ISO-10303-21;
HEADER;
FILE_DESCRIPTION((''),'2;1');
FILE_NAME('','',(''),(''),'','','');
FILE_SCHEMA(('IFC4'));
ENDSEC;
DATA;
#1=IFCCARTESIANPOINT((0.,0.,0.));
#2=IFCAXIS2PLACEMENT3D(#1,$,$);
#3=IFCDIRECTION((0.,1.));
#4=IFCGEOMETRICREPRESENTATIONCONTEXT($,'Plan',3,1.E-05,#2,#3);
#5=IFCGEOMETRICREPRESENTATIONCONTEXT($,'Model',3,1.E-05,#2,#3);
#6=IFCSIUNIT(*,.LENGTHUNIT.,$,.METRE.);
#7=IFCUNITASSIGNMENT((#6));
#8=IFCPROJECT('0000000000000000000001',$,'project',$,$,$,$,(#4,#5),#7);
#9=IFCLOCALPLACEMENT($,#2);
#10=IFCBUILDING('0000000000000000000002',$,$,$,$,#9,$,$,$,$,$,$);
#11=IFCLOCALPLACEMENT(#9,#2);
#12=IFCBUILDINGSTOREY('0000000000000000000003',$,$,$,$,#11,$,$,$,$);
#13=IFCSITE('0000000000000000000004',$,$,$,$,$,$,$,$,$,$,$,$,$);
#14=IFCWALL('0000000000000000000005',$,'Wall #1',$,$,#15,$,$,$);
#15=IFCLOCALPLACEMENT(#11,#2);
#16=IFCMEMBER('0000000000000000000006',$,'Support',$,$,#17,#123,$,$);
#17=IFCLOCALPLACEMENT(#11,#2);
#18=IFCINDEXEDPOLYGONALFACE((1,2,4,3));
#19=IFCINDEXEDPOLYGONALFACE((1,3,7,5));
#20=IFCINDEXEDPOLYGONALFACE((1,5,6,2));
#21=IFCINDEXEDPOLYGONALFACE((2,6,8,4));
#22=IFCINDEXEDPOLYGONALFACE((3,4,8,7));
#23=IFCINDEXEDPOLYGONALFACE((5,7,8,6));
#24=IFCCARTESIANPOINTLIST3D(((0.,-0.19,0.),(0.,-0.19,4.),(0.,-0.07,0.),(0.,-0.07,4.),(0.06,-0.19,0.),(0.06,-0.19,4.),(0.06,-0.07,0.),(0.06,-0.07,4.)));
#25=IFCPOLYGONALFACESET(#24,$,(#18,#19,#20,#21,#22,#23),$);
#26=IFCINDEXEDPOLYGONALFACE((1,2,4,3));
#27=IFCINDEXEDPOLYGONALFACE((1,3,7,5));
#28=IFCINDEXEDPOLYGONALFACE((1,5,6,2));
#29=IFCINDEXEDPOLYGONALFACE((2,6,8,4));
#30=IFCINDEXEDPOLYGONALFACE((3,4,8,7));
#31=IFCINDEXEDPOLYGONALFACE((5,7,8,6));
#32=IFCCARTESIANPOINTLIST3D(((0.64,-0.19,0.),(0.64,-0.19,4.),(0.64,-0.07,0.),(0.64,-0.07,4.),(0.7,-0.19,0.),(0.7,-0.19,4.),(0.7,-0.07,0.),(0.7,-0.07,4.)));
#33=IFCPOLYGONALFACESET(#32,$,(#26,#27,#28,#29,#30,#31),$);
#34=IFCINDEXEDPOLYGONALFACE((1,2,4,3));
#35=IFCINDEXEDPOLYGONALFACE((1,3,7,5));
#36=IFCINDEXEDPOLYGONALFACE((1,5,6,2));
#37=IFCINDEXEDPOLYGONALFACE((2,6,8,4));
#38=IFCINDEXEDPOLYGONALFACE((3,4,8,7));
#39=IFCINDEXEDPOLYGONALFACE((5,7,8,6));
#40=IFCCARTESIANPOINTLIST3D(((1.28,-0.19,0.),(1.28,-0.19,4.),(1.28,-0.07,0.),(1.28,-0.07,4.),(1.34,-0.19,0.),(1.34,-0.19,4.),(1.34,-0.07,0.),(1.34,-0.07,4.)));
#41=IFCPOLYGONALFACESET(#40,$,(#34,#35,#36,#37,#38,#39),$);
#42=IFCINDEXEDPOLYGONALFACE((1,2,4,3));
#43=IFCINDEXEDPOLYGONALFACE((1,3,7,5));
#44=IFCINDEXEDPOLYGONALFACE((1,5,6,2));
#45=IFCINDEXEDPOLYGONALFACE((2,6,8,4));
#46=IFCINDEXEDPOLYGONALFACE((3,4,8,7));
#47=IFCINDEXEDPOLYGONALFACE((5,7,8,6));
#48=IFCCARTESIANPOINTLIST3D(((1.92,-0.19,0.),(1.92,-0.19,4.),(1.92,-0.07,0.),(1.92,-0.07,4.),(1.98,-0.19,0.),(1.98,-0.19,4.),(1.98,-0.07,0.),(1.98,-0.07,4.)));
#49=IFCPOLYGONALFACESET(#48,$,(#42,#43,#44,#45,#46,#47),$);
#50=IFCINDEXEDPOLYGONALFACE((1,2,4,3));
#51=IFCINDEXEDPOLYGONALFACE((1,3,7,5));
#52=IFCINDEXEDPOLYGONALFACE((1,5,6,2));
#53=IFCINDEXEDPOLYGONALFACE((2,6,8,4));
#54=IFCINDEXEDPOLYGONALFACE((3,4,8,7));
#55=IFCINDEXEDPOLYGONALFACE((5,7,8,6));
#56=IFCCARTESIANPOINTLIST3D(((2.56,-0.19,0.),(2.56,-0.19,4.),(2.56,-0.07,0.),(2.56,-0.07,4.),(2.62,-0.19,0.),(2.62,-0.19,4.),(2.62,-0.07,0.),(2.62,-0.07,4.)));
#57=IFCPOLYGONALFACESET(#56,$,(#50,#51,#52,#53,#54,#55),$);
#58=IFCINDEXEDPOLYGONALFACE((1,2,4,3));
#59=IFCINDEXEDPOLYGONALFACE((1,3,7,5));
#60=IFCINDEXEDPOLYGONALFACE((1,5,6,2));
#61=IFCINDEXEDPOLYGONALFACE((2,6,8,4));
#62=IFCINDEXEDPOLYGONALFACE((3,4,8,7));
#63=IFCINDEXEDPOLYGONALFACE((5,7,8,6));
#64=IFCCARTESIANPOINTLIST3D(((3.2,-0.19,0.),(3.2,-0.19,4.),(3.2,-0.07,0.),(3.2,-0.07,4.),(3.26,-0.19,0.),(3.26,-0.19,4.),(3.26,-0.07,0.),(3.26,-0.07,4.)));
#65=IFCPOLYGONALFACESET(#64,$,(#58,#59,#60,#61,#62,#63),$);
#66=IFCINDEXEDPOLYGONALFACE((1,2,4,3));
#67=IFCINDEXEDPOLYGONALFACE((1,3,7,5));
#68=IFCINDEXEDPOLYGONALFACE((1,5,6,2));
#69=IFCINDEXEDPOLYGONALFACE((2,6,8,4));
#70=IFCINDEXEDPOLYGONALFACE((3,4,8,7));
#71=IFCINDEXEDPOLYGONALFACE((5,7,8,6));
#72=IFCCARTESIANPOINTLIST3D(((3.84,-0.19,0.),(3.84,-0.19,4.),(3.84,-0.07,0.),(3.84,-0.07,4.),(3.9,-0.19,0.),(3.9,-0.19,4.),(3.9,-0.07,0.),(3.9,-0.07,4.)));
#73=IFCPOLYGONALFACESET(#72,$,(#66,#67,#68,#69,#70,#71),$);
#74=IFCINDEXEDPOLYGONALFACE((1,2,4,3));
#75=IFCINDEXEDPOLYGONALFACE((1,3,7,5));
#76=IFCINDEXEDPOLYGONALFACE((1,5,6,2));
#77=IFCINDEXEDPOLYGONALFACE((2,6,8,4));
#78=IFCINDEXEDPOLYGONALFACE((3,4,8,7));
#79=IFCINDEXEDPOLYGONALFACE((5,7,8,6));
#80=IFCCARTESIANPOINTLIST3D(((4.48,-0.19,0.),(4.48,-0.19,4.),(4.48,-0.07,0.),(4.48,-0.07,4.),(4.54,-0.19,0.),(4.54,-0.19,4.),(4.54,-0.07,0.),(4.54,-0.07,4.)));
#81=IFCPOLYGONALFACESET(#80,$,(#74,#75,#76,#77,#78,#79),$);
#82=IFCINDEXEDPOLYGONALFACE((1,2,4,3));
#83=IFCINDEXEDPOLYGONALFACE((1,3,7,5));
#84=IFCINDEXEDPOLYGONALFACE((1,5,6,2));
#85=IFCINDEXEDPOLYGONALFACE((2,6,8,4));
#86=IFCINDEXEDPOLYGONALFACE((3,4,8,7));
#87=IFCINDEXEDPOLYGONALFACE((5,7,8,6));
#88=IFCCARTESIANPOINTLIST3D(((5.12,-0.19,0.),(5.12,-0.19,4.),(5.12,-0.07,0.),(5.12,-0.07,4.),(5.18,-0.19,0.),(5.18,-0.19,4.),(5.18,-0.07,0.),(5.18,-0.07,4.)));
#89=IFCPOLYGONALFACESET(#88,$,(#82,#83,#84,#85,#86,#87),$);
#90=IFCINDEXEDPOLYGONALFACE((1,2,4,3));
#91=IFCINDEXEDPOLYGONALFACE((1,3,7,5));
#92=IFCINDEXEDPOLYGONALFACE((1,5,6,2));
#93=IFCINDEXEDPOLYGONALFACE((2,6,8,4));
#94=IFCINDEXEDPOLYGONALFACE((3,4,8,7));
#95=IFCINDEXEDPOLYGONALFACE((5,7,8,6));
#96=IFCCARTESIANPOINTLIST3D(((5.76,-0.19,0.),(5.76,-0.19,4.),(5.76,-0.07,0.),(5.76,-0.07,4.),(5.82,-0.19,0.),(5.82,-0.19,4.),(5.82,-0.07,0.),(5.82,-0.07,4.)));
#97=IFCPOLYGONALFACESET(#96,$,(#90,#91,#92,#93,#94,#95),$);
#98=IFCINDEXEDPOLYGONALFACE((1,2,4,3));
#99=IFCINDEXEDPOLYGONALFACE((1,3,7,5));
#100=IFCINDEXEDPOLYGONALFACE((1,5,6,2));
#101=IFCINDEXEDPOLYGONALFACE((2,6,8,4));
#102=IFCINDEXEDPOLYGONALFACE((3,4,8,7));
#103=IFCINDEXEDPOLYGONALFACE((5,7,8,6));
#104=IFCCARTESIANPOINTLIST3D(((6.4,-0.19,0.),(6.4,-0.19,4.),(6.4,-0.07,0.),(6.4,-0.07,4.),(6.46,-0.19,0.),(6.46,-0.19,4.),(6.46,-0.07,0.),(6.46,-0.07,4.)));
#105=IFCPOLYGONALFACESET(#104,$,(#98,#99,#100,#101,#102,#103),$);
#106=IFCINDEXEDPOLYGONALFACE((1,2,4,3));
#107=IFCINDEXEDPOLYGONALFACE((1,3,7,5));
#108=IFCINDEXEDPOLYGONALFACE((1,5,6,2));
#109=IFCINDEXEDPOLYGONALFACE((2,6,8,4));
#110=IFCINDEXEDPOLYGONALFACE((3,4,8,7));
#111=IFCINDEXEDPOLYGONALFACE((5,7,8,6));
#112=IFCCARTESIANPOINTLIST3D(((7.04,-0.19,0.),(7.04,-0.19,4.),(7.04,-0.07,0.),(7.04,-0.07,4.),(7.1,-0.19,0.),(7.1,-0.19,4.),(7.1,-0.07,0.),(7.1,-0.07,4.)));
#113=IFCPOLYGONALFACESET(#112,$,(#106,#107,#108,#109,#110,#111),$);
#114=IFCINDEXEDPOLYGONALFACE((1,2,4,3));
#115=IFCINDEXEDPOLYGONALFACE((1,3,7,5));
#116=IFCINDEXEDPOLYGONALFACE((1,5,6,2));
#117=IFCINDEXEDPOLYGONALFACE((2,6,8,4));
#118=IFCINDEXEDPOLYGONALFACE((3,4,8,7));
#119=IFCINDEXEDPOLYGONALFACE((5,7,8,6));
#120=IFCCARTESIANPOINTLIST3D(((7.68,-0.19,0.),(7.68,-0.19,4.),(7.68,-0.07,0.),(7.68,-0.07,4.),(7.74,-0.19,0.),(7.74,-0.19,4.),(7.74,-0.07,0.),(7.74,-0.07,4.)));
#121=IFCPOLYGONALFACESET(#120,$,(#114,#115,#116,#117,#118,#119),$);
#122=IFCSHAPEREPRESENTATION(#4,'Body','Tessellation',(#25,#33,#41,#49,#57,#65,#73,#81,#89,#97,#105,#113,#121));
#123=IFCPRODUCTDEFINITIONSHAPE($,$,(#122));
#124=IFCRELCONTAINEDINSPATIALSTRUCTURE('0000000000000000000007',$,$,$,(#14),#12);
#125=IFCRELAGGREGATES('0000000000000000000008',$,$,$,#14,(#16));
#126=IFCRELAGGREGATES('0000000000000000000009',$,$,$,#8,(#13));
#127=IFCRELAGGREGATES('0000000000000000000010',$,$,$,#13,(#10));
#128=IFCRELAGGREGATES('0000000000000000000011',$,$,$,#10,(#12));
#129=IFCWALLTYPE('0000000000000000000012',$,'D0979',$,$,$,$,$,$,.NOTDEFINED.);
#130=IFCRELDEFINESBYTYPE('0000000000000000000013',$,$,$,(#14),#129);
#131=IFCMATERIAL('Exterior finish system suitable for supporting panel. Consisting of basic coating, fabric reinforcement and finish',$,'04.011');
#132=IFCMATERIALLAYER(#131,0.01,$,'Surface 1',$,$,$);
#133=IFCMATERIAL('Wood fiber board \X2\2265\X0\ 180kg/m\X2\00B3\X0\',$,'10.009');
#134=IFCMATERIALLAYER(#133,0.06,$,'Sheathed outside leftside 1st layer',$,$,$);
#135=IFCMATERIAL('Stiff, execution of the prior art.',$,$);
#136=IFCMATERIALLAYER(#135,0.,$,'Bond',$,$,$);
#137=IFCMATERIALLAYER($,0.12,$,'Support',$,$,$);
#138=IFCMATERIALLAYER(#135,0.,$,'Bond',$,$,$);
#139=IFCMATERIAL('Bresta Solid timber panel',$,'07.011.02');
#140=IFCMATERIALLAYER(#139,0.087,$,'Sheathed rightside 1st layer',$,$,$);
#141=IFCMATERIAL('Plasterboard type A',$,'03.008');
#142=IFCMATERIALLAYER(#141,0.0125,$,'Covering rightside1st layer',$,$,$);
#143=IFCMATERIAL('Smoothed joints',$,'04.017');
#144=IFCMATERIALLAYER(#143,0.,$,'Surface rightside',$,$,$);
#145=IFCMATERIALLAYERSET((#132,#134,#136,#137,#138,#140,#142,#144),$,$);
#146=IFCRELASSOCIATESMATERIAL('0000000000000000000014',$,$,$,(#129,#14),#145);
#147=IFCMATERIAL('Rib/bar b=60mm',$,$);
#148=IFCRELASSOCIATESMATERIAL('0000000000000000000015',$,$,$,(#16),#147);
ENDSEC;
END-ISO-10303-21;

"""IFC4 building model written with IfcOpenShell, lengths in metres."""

from ifc_helpers import new_model, si_unit, direction, frame, frame_2d, origin, place, context, project, spatial, rectangle, extrude, material, layer, layer_set, type_object, element, aggregate, save


model = new_model("IFC4")

# Units and contexts
plan_context = context("Plan", 3, precision=1e-05, world=origin(), true_north=direction((0.0, 1.0)))
model_context = context("Model", 3, precision=1e-05, world=origin(), true_north=direction((0.0, 1.0)))
ifc_project = project(units=[si_unit("LENGTHUNIT", "METRE")], contexts=[plan_context, model_context])

# Site, building, storey
site = spatial("IfcSite", under=ifc_project)
building_placement = place(None, origin())
building = spatial("IfcBuilding", under=site, at=building_placement)
storey_placement = place(building_placement, origin())
storey = spatial("IfcBuildingStorey", under=building, at=storey_placement)

# Wall, member
ifc_material_1 = material(Name="Exterior finish system suitable for supporting panel. Consisting of basic coating, fabric reinforcement and finish", Category="04.011")
ifc_layer_1 = layer(ifc_material_1, 0.01, Name="Surface 1")
ifc_material_2 = material(Name="Wood fiber board ≥ 180kg/m³", Category="10.009")
ifc_layer_2 = layer(ifc_material_2, 0.06, Name="Sheathed outside leftside 1st layer")
ifc_material_3 = material(Name="Stiff, execution of the prior art.")
ifc_layer_3 = layer(ifc_material_3, 0.0, Name="Bond")
ifc_layer_4 = layer(None, 0.12, Name="Support")
ifc_layer_5 = layer(ifc_material_3, 0.0, Name="Bond")
ifc_material_4 = material(Name="Bresta Solid timber panel", Category="07.011.02")
ifc_layer_6 = layer(ifc_material_4, 0.087, Name="Sheathed rightside 1st layer")
ifc_material_5 = material(Name="Plasterboard type A", Category="03.008")
ifc_layer_7 = layer(ifc_material_5, 0.0125, Name="Covering rightside1st layer")
ifc_material_6 = material(Name="Smoothed joints", Category="04.017")
ifc_layer_8 = layer(ifc_material_6, 0.0, Name="Surface rightside")
ifc_layer_set = layer_set([ifc_layer_1, ifc_layer_2, ifc_layer_3, ifc_layer_4, ifc_layer_5, ifc_layer_6, ifc_layer_7, ifc_layer_8])
wall_type = type_object("IfcWallType", Name="D0979", PredefinedType="NOTDEFINED", material=ifc_layer_set)
wall_placement = place(None, frame((0.0, 0.0, 0.0), z_axis=(0.0, -1.0, 0.0), x_axis=(1.0, 0.0, 0.0)))
wall = element("IfcWall", 1, at=wall_placement, inside=storey, type_object=wall_type, material=ifc_layer_set, Name="Wall #1")
ifc_material_7 = material(Name="Rib/bar b=60mm")
member_1_placement = place(wall_placement, origin())
member_1 = element("IfcMember", 2, at=member_1_placement, material=ifc_material_7, Name="Support", context=plan_context, shape_type="SweptSolid", body=[
    extrude(rectangle(XDim=0.06, YDim=0.12, at=frame_2d((0.03, 0.06), x_axis=(1.0, 0.0))), frame((0.0, 4.0, 0.07), z_axis=(0.0, -1.0, 0.0), x_axis=(1.0, 0.0, 0.0)), (0.0, 0.0, 1.0), 4.0),
    extrude(rectangle(XDim=0.06, YDim=0.12, at=frame_2d((0.03, 0.06), x_axis=(1.0, 0.0))), frame((0.64, 4.0, 0.07), z_axis=(0.0, -1.0, 0.0), x_axis=(1.0, 0.0, 0.0)), (0.0, 0.0, 1.0), 4.0),
    extrude(rectangle(XDim=0.06, YDim=0.12, at=frame_2d((0.03, 0.06), x_axis=(1.0, 0.0))), frame((1.28, 4.0, 0.07), z_axis=(0.0, -1.0, 0.0), x_axis=(1.0, 0.0, 0.0)), (0.0, 0.0, 1.0), 4.0),
    extrude(rectangle(XDim=0.06, YDim=0.12, at=frame_2d((0.03, 0.06), x_axis=(1.0, 0.0))), frame((1.92, 4.0, 0.07), z_axis=(0.0, -1.0, 0.0), x_axis=(1.0, 0.0, 0.0)), (0.0, 0.0, 1.0), 4.0),
    extrude(rectangle(XDim=0.06, YDim=0.12, at=frame_2d((0.03, 0.06), x_axis=(1.0, 0.0))), frame((2.56, 4.0, 0.07), z_axis=(0.0, -1.0, 0.0), x_axis=(1.0, 0.0, 0.0)), (0.0, 0.0, 1.0), 4.0),
    extrude(rectangle(XDim=0.06, YDim=0.12, at=frame_2d((0.03, 0.06), x_axis=(1.0, 0.0))), frame((3.2, 4.0, 0.07), z_axis=(0.0, -1.0, 0.0), x_axis=(1.0, 0.0, 0.0)), (0.0, 0.0, 1.0), 4.0),
    extrude(rectangle(XDim=0.06, YDim=0.12, at=frame_2d((0.03, 0.06), x_axis=(1.0, 0.0))), frame((3.84, 4.0, 0.07), z_axis=(0.0, -1.0, 0.0), x_axis=(1.0, 0.0, 0.0)), (0.0, 0.0, 1.0), 4.0),
    extrude(rectangle(XDim=0.06, YDim=0.12, at=frame_2d((0.03, 0.06), x_axis=(1.0, 0.0))), frame((4.48, 4.0, 0.07), z_axis=(0.0, -1.0, 0.0), x_axis=(1.0, 0.0, 0.0)), (0.0, 0.0, 1.0), 4.0),
    extrude(rectangle(XDim=0.06, YDim=0.12, at=frame_2d((0.03, 0.06), x_axis=(1.0, 0.0))), frame((5.12, 4.0, 0.07), z_axis=(0.0, -1.0, 0.0), x_axis=(1.0, 0.0, 0.0)), (0.0, 0.0, 1.0), 4.0),
    extrude(rectangle(XDim=0.06, YDim=0.12, at=frame_2d((0.03, 0.06), x_axis=(1.0, 0.0))), frame((5.76, 4.0, 0.07), z_axis=(0.0, -1.0, 0.0), x_axis=(1.0, 0.0, 0.0)), (0.0, 0.0, 1.0), 4.0),
    extrude(rectangle(XDim=0.06, YDim=0.12, at=frame_2d((0.03, 0.06), x_axis=(1.0, 0.0))), frame((6.4, 4.0, 0.07), z_axis=(0.0, -1.0, 0.0), x_axis=(1.0, 0.0, 0.0)), (0.0, 0.0, 1.0), 4.0),
    extrude(rectangle(XDim=0.06, YDim=0.12, at=frame_2d((0.03, 0.06), x_axis=(1.0, 0.0))), frame((7.04, 4.0, 0.07), z_axis=(0.0, -1.0, 0.0), x_axis=(1.0, 0.0, 0.0)), (0.0, 0.0, 1.0), 4.0),
    extrude(rectangle(XDim=0.06, YDim=0.12, at=frame_2d((0.03, 0.06), x_axis=(1.0, 0.0))), frame((7.68, 4.0, 0.07), z_axis=(0.0, -1.0, 0.0), x_axis=(1.0, 0.0, 0.0)), (0.0, 0.0, 1.0), 4.0),
])
aggregate(wall, [member_1])

save(model, "model.ifc")
